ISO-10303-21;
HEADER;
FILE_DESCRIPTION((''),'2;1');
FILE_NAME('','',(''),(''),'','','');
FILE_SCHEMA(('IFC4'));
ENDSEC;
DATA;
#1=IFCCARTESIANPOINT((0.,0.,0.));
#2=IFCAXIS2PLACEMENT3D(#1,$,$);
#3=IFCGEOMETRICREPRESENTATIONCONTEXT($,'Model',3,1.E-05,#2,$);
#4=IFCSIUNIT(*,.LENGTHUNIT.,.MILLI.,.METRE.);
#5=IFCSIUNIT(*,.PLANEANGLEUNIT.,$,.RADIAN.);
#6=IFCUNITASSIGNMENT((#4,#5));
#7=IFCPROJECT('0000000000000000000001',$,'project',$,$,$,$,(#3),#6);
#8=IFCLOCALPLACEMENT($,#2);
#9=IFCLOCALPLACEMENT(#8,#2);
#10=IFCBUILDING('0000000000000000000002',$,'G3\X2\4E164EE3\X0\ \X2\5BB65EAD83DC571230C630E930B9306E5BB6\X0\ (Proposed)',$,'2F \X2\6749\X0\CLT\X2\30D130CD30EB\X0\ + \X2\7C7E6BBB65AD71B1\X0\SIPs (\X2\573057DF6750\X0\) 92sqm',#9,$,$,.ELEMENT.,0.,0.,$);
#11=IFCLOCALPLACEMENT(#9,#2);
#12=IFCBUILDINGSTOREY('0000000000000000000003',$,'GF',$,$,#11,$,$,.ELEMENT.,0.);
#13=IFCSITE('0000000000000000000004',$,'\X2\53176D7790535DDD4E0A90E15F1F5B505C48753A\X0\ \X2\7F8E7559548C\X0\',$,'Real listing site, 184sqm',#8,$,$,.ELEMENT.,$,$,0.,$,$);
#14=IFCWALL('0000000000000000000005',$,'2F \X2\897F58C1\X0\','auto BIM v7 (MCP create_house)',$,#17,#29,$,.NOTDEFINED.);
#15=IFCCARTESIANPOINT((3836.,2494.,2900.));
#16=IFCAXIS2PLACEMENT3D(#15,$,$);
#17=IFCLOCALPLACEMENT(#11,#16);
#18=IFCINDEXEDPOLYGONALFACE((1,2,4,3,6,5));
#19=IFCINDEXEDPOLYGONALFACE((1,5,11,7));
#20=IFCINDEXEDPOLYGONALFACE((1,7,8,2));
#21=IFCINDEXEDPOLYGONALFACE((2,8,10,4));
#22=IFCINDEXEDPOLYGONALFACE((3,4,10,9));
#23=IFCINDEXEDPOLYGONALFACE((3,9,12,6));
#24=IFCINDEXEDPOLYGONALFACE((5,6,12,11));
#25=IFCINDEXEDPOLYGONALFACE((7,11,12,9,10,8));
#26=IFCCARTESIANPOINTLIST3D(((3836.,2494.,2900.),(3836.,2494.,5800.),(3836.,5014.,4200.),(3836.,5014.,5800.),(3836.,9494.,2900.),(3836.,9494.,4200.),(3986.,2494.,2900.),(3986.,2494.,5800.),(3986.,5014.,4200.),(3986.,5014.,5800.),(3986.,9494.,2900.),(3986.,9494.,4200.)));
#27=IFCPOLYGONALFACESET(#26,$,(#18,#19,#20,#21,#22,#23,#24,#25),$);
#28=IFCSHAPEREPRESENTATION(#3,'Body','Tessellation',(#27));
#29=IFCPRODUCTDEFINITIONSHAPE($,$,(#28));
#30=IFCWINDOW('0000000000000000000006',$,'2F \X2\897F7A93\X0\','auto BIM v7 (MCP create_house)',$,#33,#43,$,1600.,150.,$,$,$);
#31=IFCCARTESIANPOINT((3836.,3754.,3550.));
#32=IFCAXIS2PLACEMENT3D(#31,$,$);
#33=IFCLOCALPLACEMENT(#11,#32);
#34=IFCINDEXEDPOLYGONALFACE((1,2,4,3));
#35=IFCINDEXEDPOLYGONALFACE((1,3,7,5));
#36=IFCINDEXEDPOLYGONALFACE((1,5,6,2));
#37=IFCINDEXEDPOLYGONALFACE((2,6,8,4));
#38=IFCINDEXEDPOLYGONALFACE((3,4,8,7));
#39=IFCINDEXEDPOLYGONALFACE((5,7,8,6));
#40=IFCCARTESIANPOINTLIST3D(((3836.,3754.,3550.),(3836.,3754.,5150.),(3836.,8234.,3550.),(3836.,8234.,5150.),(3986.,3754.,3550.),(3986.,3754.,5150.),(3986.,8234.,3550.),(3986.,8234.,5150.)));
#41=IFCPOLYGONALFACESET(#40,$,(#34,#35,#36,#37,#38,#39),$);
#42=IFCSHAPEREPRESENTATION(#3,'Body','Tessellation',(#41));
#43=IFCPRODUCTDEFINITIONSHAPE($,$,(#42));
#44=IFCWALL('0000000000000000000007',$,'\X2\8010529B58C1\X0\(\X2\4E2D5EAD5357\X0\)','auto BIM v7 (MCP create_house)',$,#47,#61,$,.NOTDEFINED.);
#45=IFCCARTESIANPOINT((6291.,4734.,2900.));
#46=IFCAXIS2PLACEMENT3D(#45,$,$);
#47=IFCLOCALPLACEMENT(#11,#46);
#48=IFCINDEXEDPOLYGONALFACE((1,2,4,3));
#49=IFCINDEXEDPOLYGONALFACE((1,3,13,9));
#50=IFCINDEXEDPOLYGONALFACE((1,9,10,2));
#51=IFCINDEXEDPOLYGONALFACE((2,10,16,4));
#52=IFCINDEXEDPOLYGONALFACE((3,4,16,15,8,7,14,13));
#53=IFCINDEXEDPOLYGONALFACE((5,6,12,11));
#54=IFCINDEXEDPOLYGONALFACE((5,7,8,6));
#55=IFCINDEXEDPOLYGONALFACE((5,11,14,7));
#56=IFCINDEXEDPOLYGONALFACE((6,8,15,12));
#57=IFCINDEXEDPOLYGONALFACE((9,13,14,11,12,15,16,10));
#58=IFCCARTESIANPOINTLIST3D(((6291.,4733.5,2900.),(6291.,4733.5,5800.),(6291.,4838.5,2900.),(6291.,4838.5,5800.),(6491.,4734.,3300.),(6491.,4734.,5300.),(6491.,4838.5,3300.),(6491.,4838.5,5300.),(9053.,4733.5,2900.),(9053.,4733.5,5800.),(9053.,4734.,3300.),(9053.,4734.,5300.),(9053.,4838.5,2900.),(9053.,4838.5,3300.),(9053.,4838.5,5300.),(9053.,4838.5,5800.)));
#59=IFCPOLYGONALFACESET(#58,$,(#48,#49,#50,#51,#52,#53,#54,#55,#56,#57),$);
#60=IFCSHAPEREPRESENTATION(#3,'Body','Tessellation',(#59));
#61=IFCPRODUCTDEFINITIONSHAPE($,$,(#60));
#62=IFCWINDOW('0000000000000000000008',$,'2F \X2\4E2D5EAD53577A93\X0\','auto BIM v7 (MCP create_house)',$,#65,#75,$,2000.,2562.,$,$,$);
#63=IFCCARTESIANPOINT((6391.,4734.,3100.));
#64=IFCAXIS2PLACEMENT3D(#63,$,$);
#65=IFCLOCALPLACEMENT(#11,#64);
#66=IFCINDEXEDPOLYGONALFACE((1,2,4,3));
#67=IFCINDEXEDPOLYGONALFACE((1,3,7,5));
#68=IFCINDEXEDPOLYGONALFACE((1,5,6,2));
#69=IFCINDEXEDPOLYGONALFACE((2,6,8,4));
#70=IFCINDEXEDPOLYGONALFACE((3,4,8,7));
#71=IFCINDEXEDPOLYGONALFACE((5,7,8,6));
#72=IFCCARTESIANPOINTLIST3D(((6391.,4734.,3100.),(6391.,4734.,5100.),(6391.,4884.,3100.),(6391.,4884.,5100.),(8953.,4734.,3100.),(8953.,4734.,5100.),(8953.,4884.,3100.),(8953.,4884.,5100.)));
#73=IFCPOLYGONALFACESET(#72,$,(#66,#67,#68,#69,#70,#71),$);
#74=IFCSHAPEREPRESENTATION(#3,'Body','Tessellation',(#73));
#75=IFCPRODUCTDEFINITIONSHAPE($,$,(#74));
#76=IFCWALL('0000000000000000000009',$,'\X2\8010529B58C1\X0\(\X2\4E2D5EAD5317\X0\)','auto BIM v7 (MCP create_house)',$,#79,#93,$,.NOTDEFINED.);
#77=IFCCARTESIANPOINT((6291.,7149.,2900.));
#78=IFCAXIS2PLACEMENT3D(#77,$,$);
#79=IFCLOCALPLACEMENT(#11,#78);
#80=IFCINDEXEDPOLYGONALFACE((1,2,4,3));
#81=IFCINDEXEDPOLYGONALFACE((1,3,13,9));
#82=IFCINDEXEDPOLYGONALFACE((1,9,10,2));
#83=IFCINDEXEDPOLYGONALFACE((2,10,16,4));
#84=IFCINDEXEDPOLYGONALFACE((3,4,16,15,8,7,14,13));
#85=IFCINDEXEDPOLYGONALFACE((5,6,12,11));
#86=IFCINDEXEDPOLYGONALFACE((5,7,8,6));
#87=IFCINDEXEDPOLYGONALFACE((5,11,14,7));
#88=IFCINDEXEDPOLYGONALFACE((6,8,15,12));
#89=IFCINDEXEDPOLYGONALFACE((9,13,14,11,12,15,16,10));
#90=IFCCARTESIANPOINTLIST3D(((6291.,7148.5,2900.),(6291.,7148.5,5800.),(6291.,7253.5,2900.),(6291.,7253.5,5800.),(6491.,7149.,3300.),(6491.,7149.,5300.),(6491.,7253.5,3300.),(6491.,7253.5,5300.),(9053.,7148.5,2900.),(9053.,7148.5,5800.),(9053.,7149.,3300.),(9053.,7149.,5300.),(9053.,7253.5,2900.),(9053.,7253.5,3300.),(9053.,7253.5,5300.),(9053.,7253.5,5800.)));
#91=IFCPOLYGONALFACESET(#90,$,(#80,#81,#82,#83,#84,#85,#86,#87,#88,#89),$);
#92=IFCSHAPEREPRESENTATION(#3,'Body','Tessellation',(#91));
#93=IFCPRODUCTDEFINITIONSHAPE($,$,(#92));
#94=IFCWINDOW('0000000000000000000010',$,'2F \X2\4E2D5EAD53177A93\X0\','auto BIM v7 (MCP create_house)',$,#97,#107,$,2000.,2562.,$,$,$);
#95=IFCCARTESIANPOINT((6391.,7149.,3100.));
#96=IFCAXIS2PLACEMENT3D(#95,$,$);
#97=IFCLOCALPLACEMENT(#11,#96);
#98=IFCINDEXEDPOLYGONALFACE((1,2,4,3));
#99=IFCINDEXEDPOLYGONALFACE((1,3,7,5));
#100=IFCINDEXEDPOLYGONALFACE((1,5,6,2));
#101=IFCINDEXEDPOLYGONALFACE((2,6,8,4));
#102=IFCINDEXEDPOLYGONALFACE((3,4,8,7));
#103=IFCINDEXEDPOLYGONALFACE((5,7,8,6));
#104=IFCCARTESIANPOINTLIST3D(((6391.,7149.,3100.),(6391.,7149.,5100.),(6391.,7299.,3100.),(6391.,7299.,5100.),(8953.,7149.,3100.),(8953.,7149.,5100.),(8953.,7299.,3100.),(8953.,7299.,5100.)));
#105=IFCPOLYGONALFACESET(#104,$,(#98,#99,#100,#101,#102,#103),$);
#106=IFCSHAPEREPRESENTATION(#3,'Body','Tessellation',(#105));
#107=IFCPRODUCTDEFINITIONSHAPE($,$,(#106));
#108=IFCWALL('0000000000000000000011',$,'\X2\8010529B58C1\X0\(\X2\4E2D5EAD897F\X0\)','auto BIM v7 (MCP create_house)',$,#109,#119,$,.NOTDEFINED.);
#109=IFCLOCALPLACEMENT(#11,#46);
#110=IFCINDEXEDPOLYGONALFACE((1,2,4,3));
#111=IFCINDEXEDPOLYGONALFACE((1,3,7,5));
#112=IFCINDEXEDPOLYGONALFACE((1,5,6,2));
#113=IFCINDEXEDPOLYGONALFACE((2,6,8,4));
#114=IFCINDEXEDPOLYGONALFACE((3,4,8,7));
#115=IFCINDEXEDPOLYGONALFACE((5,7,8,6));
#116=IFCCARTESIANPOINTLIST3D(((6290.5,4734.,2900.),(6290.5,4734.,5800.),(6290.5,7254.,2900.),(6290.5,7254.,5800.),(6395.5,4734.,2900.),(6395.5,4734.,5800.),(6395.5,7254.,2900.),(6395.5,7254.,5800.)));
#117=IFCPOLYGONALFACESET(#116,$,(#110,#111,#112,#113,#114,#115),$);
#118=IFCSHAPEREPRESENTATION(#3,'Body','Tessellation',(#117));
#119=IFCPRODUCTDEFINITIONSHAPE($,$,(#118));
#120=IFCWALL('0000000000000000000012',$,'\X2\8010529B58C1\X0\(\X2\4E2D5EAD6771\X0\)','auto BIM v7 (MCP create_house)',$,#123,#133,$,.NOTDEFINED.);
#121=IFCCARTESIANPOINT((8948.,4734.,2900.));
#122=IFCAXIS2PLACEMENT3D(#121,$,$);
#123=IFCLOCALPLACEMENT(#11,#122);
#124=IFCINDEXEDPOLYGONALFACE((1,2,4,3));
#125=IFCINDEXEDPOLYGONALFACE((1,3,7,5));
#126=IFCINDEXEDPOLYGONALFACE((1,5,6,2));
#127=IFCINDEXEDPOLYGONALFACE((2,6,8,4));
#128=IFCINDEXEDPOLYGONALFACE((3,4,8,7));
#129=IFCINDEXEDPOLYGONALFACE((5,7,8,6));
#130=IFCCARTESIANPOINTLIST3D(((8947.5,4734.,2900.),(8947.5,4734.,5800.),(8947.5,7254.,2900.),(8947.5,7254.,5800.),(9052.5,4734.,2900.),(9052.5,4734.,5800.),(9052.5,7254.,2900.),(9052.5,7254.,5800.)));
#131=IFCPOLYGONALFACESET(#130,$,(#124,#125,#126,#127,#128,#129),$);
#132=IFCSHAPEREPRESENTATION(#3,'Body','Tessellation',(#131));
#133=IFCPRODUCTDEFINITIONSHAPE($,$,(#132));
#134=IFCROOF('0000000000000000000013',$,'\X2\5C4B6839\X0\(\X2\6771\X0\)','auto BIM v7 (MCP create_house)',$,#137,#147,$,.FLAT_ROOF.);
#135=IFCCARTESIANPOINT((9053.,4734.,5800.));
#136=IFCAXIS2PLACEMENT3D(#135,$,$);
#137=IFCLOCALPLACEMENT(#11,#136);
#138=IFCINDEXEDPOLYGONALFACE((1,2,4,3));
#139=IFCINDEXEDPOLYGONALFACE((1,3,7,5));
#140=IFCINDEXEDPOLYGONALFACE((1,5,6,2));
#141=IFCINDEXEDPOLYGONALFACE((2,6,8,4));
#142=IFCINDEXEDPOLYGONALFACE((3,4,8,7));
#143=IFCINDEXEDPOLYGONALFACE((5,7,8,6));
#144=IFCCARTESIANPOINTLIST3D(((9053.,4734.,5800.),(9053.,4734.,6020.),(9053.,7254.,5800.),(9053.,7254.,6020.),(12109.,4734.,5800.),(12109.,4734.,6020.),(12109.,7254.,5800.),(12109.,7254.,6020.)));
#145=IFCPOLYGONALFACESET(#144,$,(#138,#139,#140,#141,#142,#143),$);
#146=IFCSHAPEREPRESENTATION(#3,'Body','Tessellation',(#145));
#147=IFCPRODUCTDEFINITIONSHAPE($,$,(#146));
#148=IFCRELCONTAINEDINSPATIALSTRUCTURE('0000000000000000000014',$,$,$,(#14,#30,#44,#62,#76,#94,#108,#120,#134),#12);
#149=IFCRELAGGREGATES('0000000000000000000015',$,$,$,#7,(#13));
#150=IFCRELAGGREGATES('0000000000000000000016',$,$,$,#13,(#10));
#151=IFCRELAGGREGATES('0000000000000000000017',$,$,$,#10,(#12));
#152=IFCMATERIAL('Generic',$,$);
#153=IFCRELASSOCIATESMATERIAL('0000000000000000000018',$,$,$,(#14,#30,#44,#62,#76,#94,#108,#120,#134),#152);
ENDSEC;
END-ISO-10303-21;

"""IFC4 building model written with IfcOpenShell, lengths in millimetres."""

from ifc_helpers import new_model, si_unit, frame, frame_2d, origin, place, context, project, spatial, rectangle, extrude, material, element, fill, save


model = new_model("IFC4")

# Units and contexts
model_context = context("Model", 3, precision=1e-05, world=origin())
ifc_project = project(units=[si_unit("LENGTHUNIT", "METRE", prefix="MILLI"), si_unit("PLANEANGLEUNIT", "RADIAN")], contexts=[model_context])

# Site, building, storey
site_placement = place(None, origin())
site = spatial("IfcSite", under=ifc_project, at=site_placement, Name="北海道川上郡弟子屈町 美留和", ObjectType="Real listing site, 184sqm", CompositionType="ELEMENT", RefElevation=0.0)
building_placement = place(site_placement, origin())
building = spatial("IfcBuilding", under=site, at=building_placement, Name="G3世代 家庭菜園テラスの家 (Proposed)", ObjectType="2F 杉CLTパネル + 籾殻断熱SIPs (地域材) 92sqm", CompositionType="ELEMENT", ElevationOfRefHeight=0.0, ElevationOfTerrain=0.0)
storey_placement = place(building_placement, origin())
storey = spatial("IfcBuildingStorey", under=building, at=storey_placement, Name="GF", CompositionType="ELEMENT", Elevation=0.0)

# Shared definitions
ifc_material = material(Name="Generic")

# Walls, openings, windows
wall_1_placement = place(storey_placement, frame((3836.0, 2494.0, 2900.0)))
wall_1 = element("IfcWall", 1, at=wall_1_placement, inside=storey, material=ifc_material, Name="2F 西壁", Description="auto BIM v7 (MCP create_house)", PredefinedType="NOTDEFINED", context=model_context, shape_type="SweptSolid", body=[
    extrude(rectangle(XDim=150.0, YDim=7000.0, at=frame_2d((75.0, 3500.0))), frame((3836.0, 2494.0, 2900.0)), (0.0, 0.0, 1.0), 2900.0),
])
opening_1_placement = place(storey_placement, frame((3836.0, 3754.0, 3550.0)))
opening_1 = element("IfcOpeningElement", 2, at=opening_1_placement, cuts=wall_1, PredefinedType="NOTDEFINED", context=model_context, shape_type="SweptSolid", body=[
    extrude(rectangle(XDim=150.0, YDim=4480.0, at=frame_2d((75.0, 2240.0))), frame((3836.0, 3754.0, 3550.0)), (0.0, 0.0, 1.0), 1600.0),
])
window_1_placement = place(storey_placement, frame((3836.0, 3754.0, 3550.0)))
window_1 = element("IfcWindow", 3, at=window_1_placement, inside=storey, material=ifc_material, Name="2F 西窓", Description="auto BIM v7 (MCP create_house)", OverallHeight=1600.0, OverallWidth=150.0, context=model_context, shape_type="SweptSolid", body=[
    extrude(rectangle(XDim=150.0, YDim=4480.0, at=frame_2d((75.0, 2240.0))), frame((3836.0, 3754.0, 3550.0)), (0.0, 0.0, 1.0), 1600.0),
])
fill(opening_1, window_1)
wall_2_placement = place(storey_placement, frame((6291.0, 4734.0, 2900.0)))
wall_2 = element("IfcWall", 4, at=wall_2_placement, inside=storey, material=ifc_material, Name="耐力壁(中庭南)", Description="auto BIM v7 (MCP create_house)", PredefinedType="NOTDEFINED", context=model_context, shape_type="SweptSolid", body=[
    extrude(rectangle(XDim=2762.0, YDim=105.0, at=frame_2d((1381.0, 52.0))), frame((6291.0, 4734.0, 2900.0)), (0.0, 0.0, 1.0), 2900.0),
])
opening_2_placement = place(storey_placement, frame((6391.0, 4734.0, 3100.0)))
opening_2 = element("IfcOpeningElement", 5, at=opening_2_placement, cuts=wall_2, PredefinedType="NOTDEFINED", context=model_context, shape_type="SweptSolid", body=[
    extrude(rectangle(XDim=2562.0, YDim=150.0, at=frame_2d((1281.0, 75.0))), frame((6391.0, 4734.0, 3100.0)), (0.0, 0.0, 1.0), 2000.0),
])
window_2_placement = place(storey_placement, frame((6391.0, 4734.0, 3100.0)))
window_2 = element("IfcWindow", 6, at=window_2_placement, inside=storey, material=ifc_material, Name="2F 中庭南窓", Description="auto BIM v7 (MCP create_house)", OverallHeight=2000.0, OverallWidth=2562.0, context=model_context, shape_type="SweptSolid", body=[
    extrude(rectangle(XDim=2562.0, YDim=150.0, at=frame_2d((1281.0, 75.0))), frame((6391.0, 4734.0, 3100.0)), (0.0, 0.0, 1.0), 2000.0),
])
fill(opening_2, window_2)
wall_3_placement = place(storey_placement, frame((6291.0, 7149.0, 2900.0)))
wall_3 = element("IfcWall", 7, at=wall_3_placement, inside=storey, material=ifc_material, Name="耐力壁(中庭北)", Description="auto BIM v7 (MCP create_house)", PredefinedType="NOTDEFINED", context=model_context, shape_type="SweptSolid", body=[
    extrude(rectangle(XDim=2762.0, YDim=105.0, at=frame_2d((1381.0, 52.0))), frame((6291.0, 7149.0, 2900.0)), (0.0, 0.0, 1.0), 2900.0),
])
opening_3_placement = place(storey_placement, frame((6391.0, 7149.0, 3100.0)))
opening_3 = element("IfcOpeningElement", 8, at=opening_3_placement, cuts=wall_3, PredefinedType="NOTDEFINED", context=model_context, shape_type="SweptSolid", body=[
    extrude(rectangle(XDim=2562.0, YDim=150.0, at=frame_2d((1281.0, 75.0))), frame((6391.0, 7149.0, 3100.0)), (0.0, 0.0, 1.0), 2000.0),
])
window_3_placement = place(storey_placement, frame((6391.0, 7149.0, 3100.0)))
window_3 = element("IfcWindow", 9, at=window_3_placement, inside=storey, material=ifc_material, Name="2F 中庭北窓", Description="auto BIM v7 (MCP create_house)", OverallHeight=2000.0, OverallWidth=2562.0, context=model_context, shape_type="SweptSolid", body=[
    extrude(rectangle(XDim=2562.0, YDim=150.0, at=frame_2d((1281.0, 75.0))), frame((6391.0, 7149.0, 3100.0)), (0.0, 0.0, 1.0), 2000.0),
])
fill(opening_3, window_3)

# Walls
wall_4_placement = place(storey_placement, frame((6291.0, 4734.0, 2900.0)))
element("IfcWall", 10, at=wall_4_placement, inside=storey, material=ifc_material, Name="耐力壁(中庭西)", Description="auto BIM v7 (MCP create_house)", PredefinedType="NOTDEFINED", context=model_context, shape_type="SweptSolid", body=[
    extrude(rectangle(XDim=105.0, YDim=2520.0, at=frame_2d((52.0, 1260.0))), frame((6291.0, 4734.0, 2900.0)), (0.0, 0.0, 1.0), 2900.0),
])
wall_5_placement = place(storey_placement, frame((8948.0, 4734.0, 2900.0)))
element("IfcWall", 11, at=wall_5_placement, inside=storey, material=ifc_material, Name="耐力壁(中庭東)", Description="auto BIM v7 (MCP create_house)", PredefinedType="NOTDEFINED", context=model_context, shape_type="SweptSolid", body=[
    extrude(rectangle(XDim=105.0, YDim=2520.0, at=frame_2d((52.0, 1260.0))), frame((8948.0, 4734.0, 2900.0)), (0.0, 0.0, 1.0), 2900.0),
])

# Roof
for number, where, name in (
    (12, (9053.0, 4734.0, 5800.0), "屋根(東)"),
):
    element("IfcRoof", number, at=place(storey_placement, frame(where)), inside=storey, material=ifc_material, Name=name, Description="auto BIM v7 (MCP create_house)", PredefinedType="FLAT_ROOF", context=model_context, shape_type="SweptSolid", body=[
        extrude(rectangle(XDim=3056.0, YDim=2520.0, at=frame_2d((1528.0, 1260.0))), frame((9053.0, 4734.0, 5800.0)), (0.0, 0.0, 1.0), 220.0),
    ])

save(model, "model.ifc")
